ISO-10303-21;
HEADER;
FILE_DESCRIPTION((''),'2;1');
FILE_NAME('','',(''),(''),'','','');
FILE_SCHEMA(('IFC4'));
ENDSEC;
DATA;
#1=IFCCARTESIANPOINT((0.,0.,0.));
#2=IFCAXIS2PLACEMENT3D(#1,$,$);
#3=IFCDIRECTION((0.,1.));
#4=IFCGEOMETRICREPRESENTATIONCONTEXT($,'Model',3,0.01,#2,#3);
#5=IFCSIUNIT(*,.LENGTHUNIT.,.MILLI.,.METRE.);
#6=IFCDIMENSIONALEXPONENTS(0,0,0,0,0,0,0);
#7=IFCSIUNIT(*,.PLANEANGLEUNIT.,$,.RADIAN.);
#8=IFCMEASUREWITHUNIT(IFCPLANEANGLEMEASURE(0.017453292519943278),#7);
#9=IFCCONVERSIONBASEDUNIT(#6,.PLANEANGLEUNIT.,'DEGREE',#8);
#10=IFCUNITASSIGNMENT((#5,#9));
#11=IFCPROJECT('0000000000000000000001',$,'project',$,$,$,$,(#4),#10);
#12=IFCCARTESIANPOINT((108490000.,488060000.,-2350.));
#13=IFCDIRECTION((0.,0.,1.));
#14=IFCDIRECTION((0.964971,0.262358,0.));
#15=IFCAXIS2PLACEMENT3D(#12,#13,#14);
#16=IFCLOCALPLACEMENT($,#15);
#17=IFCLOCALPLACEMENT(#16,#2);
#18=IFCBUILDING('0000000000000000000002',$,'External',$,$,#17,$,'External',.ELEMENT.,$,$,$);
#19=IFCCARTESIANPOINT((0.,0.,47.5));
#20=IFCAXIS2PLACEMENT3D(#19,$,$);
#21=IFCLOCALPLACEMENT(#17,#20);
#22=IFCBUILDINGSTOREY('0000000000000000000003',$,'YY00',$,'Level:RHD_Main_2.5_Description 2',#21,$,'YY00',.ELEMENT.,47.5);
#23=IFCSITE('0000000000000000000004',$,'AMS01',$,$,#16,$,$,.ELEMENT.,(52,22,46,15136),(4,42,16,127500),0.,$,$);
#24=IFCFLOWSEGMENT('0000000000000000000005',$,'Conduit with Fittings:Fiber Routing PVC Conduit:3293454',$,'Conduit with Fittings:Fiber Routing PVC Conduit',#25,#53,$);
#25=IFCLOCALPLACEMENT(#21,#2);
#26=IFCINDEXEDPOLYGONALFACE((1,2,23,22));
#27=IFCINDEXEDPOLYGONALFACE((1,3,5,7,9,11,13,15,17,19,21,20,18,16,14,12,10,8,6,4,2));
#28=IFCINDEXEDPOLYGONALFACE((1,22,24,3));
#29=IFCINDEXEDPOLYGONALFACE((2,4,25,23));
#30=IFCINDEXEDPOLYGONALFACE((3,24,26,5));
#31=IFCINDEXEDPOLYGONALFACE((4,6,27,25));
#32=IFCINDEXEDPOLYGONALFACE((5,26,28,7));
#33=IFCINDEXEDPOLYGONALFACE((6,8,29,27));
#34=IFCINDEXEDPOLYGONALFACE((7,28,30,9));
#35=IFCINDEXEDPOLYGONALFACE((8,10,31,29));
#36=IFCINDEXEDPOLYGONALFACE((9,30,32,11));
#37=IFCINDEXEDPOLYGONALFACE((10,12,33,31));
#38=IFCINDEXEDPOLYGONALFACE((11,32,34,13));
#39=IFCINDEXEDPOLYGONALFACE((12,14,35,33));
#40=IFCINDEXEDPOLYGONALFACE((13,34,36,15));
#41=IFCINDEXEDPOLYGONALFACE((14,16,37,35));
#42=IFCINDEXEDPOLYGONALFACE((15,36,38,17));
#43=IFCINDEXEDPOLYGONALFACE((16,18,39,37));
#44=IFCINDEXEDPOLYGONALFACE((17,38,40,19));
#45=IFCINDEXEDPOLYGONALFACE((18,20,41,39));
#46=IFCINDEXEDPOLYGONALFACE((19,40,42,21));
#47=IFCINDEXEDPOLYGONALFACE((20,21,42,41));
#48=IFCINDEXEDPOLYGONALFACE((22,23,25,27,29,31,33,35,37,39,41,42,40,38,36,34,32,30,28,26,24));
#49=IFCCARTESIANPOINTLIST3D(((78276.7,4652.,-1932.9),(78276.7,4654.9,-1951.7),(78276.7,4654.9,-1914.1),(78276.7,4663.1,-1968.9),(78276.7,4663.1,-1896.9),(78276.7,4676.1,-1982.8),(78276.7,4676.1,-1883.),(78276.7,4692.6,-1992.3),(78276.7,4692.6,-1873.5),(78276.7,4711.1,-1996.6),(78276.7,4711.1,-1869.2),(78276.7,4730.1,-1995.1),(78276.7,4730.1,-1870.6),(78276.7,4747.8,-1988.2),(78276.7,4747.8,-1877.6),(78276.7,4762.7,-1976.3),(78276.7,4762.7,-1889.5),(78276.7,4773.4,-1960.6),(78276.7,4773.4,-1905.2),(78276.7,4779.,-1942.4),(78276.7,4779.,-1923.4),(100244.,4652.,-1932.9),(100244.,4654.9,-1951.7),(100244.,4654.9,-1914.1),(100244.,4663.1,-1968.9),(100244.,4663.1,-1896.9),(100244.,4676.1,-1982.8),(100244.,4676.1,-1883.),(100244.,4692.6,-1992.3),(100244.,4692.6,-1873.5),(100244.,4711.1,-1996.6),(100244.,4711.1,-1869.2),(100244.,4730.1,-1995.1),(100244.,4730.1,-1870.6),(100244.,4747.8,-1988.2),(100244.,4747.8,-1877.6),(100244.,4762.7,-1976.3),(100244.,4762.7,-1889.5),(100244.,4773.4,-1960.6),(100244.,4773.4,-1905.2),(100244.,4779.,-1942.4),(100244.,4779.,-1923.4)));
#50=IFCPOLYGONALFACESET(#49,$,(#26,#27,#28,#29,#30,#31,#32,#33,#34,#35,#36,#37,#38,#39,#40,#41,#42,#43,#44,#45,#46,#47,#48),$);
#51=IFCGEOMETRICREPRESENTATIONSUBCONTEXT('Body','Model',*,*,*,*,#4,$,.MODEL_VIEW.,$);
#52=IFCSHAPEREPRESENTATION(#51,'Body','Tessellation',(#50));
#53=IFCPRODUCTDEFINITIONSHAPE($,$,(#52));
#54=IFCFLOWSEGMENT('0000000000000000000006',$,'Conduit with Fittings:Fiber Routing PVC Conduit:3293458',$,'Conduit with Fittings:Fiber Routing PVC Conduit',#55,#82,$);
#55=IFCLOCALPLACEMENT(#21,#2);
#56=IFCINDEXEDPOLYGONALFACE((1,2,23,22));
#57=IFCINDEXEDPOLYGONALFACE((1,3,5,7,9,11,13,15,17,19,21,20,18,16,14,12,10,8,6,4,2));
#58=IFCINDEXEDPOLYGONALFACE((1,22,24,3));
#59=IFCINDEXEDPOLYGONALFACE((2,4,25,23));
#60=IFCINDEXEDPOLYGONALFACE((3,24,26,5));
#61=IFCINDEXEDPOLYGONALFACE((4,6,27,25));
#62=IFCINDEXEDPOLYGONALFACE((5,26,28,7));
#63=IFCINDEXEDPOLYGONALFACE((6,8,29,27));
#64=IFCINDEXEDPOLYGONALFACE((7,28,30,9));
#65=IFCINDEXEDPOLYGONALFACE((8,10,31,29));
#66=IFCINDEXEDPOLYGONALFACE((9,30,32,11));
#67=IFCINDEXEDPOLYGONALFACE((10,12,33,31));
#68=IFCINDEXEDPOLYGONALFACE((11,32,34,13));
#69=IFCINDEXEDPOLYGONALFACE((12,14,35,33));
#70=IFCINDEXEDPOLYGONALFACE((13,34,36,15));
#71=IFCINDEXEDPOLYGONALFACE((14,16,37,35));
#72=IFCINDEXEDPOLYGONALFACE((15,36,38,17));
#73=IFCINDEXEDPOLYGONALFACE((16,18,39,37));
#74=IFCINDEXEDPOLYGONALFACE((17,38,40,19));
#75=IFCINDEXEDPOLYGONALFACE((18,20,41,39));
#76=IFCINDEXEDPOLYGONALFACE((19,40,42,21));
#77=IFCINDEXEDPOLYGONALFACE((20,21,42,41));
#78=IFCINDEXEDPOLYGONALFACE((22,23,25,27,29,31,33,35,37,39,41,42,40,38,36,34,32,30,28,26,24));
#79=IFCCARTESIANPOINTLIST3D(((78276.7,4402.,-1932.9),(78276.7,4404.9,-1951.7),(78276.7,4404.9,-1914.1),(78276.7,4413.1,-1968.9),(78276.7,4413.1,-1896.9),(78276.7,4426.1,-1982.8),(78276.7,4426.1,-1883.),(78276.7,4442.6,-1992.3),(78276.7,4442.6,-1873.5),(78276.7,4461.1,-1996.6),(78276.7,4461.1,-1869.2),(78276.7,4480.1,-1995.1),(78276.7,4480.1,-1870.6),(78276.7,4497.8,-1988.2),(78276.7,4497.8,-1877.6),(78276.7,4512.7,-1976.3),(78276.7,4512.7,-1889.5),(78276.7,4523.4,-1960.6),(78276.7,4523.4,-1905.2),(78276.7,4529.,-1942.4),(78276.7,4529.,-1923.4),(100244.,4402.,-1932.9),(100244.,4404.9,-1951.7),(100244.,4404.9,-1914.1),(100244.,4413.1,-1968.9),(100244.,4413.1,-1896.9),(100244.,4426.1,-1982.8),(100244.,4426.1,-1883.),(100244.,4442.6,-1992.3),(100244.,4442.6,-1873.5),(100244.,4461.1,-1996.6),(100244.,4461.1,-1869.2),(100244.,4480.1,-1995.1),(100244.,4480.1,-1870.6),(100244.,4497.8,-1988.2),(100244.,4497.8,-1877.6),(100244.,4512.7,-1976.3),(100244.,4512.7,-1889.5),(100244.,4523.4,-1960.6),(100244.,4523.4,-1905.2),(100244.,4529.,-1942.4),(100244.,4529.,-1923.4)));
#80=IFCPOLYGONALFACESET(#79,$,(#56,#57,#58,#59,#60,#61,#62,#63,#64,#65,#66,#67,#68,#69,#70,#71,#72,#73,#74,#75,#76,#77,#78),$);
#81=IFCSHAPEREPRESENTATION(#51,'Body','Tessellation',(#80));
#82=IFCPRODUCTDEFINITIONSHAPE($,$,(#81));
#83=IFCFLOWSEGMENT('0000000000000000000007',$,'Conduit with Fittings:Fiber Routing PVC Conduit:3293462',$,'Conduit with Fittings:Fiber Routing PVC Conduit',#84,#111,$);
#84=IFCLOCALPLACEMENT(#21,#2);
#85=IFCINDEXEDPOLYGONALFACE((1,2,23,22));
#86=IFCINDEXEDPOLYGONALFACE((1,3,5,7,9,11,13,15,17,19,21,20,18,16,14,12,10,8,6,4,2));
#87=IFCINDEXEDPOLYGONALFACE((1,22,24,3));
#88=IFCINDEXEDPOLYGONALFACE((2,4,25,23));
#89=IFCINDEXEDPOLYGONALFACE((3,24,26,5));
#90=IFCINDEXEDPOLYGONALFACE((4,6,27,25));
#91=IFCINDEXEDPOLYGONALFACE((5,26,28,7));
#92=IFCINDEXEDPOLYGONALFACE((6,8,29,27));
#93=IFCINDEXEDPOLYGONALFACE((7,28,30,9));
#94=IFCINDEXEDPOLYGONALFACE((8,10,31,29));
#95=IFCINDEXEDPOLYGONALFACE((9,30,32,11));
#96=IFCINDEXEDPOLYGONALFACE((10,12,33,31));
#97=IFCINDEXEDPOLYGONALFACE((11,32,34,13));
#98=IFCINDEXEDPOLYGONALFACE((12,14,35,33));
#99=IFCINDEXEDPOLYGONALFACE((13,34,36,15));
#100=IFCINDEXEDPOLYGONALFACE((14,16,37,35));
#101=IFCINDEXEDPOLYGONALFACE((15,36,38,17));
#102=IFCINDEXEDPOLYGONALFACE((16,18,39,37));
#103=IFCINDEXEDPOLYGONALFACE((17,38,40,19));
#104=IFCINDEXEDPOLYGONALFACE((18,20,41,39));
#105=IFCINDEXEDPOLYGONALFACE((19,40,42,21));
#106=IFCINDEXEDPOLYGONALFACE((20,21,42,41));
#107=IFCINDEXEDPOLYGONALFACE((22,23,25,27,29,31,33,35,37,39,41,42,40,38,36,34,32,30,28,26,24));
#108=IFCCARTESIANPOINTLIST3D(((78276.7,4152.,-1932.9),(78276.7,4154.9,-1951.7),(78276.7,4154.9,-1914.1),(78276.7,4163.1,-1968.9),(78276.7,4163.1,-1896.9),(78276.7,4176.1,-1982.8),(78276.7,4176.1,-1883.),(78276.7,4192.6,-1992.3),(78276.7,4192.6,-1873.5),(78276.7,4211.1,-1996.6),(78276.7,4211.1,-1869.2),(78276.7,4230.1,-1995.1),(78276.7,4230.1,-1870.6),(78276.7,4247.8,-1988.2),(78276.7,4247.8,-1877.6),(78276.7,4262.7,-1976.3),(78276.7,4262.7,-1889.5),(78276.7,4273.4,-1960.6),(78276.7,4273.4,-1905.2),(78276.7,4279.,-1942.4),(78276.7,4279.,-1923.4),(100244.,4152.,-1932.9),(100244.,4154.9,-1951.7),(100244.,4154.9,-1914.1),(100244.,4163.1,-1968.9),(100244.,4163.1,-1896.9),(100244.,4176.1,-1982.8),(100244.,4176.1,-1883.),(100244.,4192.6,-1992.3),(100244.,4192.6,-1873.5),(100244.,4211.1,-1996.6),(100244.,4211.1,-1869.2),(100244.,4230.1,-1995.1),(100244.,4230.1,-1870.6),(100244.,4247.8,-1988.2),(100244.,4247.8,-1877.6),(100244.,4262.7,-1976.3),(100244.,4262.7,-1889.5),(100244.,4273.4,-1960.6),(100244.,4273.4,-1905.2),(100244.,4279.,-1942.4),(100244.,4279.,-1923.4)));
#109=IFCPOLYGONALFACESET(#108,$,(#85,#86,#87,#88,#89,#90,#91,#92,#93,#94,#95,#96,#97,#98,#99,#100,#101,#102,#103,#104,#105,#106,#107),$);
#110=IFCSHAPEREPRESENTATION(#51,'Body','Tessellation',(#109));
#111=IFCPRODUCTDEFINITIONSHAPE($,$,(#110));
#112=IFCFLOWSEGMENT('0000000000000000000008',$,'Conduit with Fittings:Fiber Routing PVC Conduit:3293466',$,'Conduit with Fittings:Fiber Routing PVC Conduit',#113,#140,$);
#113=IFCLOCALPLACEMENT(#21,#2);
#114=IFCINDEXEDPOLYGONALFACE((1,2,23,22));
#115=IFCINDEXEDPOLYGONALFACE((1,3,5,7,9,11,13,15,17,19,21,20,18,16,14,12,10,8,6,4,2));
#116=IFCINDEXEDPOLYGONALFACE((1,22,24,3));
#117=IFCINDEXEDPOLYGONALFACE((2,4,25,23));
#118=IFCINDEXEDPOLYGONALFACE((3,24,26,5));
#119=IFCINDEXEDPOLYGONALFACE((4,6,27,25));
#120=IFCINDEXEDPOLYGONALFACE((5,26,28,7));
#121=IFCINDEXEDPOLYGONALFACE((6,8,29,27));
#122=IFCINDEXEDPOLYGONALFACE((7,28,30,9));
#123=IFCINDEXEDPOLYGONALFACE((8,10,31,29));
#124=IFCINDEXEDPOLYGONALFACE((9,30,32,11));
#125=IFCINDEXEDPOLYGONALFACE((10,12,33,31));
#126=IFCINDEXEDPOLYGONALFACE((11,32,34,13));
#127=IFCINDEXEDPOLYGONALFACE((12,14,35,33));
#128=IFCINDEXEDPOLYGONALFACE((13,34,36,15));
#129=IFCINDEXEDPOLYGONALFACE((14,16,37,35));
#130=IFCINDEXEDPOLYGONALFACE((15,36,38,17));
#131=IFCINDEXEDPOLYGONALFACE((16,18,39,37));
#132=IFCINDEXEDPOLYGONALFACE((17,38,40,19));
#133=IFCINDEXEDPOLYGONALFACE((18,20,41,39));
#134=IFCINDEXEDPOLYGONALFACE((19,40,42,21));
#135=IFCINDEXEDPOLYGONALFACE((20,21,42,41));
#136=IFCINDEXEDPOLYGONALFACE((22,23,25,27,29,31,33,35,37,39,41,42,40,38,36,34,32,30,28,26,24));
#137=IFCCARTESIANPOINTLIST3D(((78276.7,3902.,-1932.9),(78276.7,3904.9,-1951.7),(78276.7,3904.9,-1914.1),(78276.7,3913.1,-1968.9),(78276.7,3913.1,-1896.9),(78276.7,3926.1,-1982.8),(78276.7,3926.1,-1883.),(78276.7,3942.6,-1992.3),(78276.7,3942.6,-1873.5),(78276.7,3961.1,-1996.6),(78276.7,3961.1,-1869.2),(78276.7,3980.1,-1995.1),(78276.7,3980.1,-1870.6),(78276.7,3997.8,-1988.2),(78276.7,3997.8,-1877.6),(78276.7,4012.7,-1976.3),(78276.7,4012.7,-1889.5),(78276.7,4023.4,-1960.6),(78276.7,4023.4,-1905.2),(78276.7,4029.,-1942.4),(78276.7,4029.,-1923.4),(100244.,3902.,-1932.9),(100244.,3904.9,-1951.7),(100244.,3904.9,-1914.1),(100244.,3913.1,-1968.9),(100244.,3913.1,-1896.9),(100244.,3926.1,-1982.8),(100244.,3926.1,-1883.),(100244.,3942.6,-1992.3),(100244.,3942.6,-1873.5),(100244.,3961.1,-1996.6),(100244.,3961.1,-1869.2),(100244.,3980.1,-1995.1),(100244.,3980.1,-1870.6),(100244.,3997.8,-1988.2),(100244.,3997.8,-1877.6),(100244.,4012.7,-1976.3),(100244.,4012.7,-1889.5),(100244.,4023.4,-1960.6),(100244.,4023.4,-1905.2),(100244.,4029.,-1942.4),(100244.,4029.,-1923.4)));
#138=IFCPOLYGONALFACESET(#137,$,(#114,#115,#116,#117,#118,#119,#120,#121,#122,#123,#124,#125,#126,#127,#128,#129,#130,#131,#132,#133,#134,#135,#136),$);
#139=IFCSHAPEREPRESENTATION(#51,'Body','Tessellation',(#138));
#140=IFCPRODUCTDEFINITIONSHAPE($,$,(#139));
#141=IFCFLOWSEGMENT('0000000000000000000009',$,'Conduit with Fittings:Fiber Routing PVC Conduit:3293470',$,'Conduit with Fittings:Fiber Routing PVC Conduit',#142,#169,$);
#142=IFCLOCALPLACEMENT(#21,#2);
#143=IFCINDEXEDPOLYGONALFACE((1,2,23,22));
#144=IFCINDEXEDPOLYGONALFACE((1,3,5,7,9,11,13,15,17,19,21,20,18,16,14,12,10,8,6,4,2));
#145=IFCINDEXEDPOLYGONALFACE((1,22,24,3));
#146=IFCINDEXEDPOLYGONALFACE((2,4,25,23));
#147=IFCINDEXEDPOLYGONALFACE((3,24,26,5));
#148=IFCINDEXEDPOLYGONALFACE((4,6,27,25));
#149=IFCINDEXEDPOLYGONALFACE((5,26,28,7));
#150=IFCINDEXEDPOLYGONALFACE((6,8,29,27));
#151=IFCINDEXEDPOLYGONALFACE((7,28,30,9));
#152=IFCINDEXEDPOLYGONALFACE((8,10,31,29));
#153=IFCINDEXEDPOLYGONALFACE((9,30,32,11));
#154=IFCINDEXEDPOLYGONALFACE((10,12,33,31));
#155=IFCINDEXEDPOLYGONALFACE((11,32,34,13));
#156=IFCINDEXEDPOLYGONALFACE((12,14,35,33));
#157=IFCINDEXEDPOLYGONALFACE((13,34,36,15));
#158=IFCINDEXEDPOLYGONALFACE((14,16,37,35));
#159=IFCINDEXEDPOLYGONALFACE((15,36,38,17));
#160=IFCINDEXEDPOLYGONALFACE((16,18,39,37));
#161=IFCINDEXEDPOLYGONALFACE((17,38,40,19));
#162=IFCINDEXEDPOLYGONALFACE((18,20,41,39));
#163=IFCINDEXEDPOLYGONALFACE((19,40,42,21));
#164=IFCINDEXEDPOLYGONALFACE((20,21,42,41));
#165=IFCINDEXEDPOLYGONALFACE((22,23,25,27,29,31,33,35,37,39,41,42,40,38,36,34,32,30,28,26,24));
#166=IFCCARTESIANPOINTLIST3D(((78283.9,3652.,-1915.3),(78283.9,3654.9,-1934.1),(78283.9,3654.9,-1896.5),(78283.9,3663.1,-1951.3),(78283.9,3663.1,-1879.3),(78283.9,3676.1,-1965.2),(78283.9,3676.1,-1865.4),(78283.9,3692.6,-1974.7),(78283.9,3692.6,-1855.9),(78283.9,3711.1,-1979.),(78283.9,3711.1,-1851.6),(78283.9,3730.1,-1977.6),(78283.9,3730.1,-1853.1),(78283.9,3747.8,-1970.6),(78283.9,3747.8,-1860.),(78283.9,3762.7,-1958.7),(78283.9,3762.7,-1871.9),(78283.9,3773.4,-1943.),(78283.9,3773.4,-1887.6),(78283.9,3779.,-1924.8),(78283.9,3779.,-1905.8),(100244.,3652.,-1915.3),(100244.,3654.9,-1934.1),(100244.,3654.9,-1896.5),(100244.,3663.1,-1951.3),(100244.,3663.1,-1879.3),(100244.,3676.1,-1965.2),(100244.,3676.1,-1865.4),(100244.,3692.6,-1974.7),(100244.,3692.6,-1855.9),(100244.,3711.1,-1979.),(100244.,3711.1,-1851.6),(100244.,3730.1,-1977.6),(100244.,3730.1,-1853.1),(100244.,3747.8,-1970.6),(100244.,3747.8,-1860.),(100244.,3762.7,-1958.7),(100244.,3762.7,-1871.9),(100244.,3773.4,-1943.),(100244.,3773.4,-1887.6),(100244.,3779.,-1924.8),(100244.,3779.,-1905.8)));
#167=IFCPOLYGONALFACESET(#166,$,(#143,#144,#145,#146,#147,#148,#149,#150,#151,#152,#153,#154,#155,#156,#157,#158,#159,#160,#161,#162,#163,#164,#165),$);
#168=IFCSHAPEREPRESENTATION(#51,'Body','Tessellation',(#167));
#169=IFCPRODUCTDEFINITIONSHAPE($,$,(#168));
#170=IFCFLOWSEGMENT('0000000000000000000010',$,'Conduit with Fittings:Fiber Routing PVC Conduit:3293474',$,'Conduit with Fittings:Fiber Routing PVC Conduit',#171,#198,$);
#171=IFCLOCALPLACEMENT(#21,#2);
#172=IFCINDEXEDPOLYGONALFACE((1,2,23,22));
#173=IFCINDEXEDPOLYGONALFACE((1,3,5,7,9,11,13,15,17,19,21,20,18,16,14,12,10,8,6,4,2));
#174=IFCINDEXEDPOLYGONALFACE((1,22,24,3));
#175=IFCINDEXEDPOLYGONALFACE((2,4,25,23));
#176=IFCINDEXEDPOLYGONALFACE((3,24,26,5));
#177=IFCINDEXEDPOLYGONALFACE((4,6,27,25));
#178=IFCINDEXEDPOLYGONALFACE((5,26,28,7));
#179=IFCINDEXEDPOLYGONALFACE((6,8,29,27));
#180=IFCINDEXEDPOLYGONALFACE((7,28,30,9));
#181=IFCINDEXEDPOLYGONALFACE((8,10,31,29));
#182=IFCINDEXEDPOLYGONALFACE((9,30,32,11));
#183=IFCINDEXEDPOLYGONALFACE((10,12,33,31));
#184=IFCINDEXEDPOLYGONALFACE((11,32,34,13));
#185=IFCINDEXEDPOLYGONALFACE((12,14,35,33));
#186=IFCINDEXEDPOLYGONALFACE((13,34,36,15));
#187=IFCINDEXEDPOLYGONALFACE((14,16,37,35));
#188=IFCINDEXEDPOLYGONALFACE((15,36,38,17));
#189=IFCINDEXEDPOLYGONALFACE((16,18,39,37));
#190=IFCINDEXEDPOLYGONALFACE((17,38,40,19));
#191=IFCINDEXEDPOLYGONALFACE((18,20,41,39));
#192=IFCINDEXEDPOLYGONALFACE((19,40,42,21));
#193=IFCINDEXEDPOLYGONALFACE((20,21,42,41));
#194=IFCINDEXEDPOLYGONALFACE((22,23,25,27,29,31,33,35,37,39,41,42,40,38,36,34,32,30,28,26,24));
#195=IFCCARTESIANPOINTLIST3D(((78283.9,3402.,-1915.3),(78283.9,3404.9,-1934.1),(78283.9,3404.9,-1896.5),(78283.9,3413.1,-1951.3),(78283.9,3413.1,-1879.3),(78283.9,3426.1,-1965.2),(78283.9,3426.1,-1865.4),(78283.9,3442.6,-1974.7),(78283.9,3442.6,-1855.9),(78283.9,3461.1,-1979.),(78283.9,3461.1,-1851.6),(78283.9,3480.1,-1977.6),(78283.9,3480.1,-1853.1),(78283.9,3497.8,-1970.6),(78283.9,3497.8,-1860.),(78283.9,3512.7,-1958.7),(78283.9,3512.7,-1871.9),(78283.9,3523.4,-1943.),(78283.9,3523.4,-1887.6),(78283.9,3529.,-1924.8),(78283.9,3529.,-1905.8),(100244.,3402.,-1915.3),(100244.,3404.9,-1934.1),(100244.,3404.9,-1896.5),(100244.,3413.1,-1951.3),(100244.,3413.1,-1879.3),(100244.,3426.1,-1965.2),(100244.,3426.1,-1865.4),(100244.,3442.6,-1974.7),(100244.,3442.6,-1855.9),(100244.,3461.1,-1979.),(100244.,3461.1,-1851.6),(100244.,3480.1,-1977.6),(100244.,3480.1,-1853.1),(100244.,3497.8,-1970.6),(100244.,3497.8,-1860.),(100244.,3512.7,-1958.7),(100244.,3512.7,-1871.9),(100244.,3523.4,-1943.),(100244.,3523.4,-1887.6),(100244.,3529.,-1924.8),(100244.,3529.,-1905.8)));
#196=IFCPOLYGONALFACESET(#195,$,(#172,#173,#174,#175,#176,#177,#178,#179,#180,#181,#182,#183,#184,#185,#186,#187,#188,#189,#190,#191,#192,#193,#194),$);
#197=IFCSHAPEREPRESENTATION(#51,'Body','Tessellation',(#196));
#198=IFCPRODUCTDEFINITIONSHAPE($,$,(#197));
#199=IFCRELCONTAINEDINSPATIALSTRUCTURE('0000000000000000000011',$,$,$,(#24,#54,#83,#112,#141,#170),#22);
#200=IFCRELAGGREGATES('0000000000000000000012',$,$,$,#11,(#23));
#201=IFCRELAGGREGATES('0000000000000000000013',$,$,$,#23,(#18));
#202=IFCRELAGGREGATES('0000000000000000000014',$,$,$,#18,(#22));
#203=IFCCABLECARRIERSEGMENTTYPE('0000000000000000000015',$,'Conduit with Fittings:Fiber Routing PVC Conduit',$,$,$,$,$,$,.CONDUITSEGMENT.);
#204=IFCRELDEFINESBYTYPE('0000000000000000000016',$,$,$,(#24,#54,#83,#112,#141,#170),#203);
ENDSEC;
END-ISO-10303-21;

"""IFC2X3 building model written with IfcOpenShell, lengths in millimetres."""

from ifc_helpers import new_model, entity, si_unit, converted_unit, direction, frame, frame_2d, origin, place, context, subcontext, project, spatial, circle, extrude, type_object, element, save


model = new_model("IFC2X3")

# Units and contexts
model_context = context("Model", 3, precision=0.01, world=origin(), true_north=direction((0.0, 1.0)))
body_context = subcontext(model_context, "Body", "Model", "MODEL_VIEW")
ifc_project = project(units=[si_unit("LENGTHUNIT", "METRE", prefix="MILLI"), converted_unit("PLANEANGLEUNIT", "DEGREE", entity("IfcPlaneAngleMeasure", 0.017453292519943278), si_unit("PLANEANGLEUNIT", "RADIAN"), dimensions=[0, 0, 0, 0, 0, 0, 0])], contexts=[model_context])

# Site, building, storey
site_placement = place(None, frame((108490000.0, 488060000.0, -2350.0), z_axis=(0.0, 0.0, 1.0), x_axis=(0.964971, 0.262358, 0.0)))
site = spatial("IfcSite", under=ifc_project, at=site_placement, Name="AMS01", CompositionType="ELEMENT", RefLatitude=(52, 22, 46, 15136), RefLongitude=(4, 42, 16, 127500), RefElevation=0.0)
building_placement = place(site_placement, origin())
building = spatial("IfcBuilding", under=site, at=building_placement, Name="External", LongName="External", CompositionType="ELEMENT")
storey_placement = place(building_placement, frame((0.0, 0.0, 47.5)))
storey = spatial("IfcBuildingStorey", under=building, at=storey_placement, Name="YY00", ObjectType="Level:RHD_Main_2.5_Description 2", LongName="YY00", CompositionType="ELEMENT", Elevation=47.5)

# Flow segments
cable_carrier_segment_type = type_object("IfcCableCarrierSegmentType", Name="Conduit with Fittings:Fiber Routing PVC Conduit", PredefinedType="CONDUITSEGMENT")
flow_segment_1_placement = place(storey_placement, origin())
element("IfcFlowSegment", 1, at=flow_segment_1_placement, inside=storey, type_object=cable_carrier_segment_type, Name="Conduit with Fittings:Fiber Routing PVC Conduit:3293454", ObjectType="Conduit with Fittings:Fiber Routing PVC Conduit", context=body_context, shape_type="SweptSolid", body=[
    extrude(circle(Radius=63.9, at=frame_2d((0.0, 0.0), x_axis=(1.0, 0.0))), frame((78276.7, 4715.9, -1932.9), z_axis=(1.0, 0.0, 0.0), x_axis=(0.0, -1.0, 0.0)), (0.0, 0.0, 1.0), 21967.3),
])
flow_segment_2_placement = place(storey_placement, origin())
element("IfcFlowSegment", 2, at=flow_segment_2_placement, inside=storey, type_object=cable_carrier_segment_type, Name="Conduit with Fittings:Fiber Routing PVC Conduit:3293458", ObjectType="Conduit with Fittings:Fiber Routing PVC Conduit", context=body_context, shape_type="SweptSolid", body=[
    extrude(circle(Radius=63.9, at=frame_2d((0.0, 0.0), x_axis=(1.0, 0.0))), frame((78276.7, 4465.9, -1932.9), z_axis=(1.0, 0.0, 0.0), x_axis=(0.0, -1.0, 0.0)), (0.0, 0.0, 1.0), 21967.3),
])
flow_segment_3_placement = place(storey_placement, origin())
element("IfcFlowSegment", 3, at=flow_segment_3_placement, inside=storey, type_object=cable_carrier_segment_type, Name="Conduit with Fittings:Fiber Routing PVC Conduit:3293462", ObjectType="Conduit with Fittings:Fiber Routing PVC Conduit", context=body_context, shape_type="SweptSolid", body=[
    extrude(circle(Radius=63.9, at=frame_2d((0.0, 0.0), x_axis=(1.0, 0.0))), frame((78276.7, 4215.9, -1932.9), z_axis=(1.0, 0.0, 0.0), x_axis=(0.0, -1.0, 0.0)), (0.0, 0.0, 1.0), 21967.3),
])
flow_segment_4_placement = place(storey_placement, origin())
element("IfcFlowSegment", 4, at=flow_segment_4_placement, inside=storey, type_object=cable_carrier_segment_type, Name="Conduit with Fittings:Fiber Routing PVC Conduit:3293466", ObjectType="Conduit with Fittings:Fiber Routing PVC Conduit", context=body_context, shape_type="SweptSolid", body=[
    extrude(circle(Radius=63.9, at=frame_2d((0.0, 0.0), x_axis=(1.0, 0.0))), frame((78276.7, 3965.9, -1932.9), z_axis=(1.0, 0.0, 0.0), x_axis=(0.0, -1.0, 0.0)), (0.0, 0.0, 1.0), 21967.3),
])
flow_segment_5_placement = place(storey_placement, origin())
element("IfcFlowSegment", 5, at=flow_segment_5_placement, inside=storey, type_object=cable_carrier_segment_type, Name="Conduit with Fittings:Fiber Routing PVC Conduit:3293470", ObjectType="Conduit with Fittings:Fiber Routing PVC Conduit", context=body_context, shape_type="SweptSolid", body=[
    extrude(circle(Radius=63.9, at=frame_2d((0.0, 0.0), x_axis=(1.0, 0.0))), frame((78283.9, 3715.9, -1915.3), z_axis=(1.0, 0.0, 0.0), x_axis=(0.0, -1.0, 0.0)), (0.0, 0.0, 1.0), 21960.0),
])
flow_segment_6_placement = place(storey_placement, origin())
element("IfcFlowSegment", 6, at=flow_segment_6_placement, inside=storey, type_object=cable_carrier_segment_type, Name="Conduit with Fittings:Fiber Routing PVC Conduit:3293474", ObjectType="Conduit with Fittings:Fiber Routing PVC Conduit", context=body_context, shape_type="SweptSolid", body=[
    extrude(circle(Radius=63.9, at=frame_2d((0.0, 0.0), x_axis=(1.0, 0.0))), frame((78283.9, 3465.9, -1915.3), z_axis=(1.0, 0.0, 0.0), x_axis=(0.0, -1.0, 0.0)), (0.0, 0.0, 1.0), 21960.0),
])

save(model, "model.ifc")
